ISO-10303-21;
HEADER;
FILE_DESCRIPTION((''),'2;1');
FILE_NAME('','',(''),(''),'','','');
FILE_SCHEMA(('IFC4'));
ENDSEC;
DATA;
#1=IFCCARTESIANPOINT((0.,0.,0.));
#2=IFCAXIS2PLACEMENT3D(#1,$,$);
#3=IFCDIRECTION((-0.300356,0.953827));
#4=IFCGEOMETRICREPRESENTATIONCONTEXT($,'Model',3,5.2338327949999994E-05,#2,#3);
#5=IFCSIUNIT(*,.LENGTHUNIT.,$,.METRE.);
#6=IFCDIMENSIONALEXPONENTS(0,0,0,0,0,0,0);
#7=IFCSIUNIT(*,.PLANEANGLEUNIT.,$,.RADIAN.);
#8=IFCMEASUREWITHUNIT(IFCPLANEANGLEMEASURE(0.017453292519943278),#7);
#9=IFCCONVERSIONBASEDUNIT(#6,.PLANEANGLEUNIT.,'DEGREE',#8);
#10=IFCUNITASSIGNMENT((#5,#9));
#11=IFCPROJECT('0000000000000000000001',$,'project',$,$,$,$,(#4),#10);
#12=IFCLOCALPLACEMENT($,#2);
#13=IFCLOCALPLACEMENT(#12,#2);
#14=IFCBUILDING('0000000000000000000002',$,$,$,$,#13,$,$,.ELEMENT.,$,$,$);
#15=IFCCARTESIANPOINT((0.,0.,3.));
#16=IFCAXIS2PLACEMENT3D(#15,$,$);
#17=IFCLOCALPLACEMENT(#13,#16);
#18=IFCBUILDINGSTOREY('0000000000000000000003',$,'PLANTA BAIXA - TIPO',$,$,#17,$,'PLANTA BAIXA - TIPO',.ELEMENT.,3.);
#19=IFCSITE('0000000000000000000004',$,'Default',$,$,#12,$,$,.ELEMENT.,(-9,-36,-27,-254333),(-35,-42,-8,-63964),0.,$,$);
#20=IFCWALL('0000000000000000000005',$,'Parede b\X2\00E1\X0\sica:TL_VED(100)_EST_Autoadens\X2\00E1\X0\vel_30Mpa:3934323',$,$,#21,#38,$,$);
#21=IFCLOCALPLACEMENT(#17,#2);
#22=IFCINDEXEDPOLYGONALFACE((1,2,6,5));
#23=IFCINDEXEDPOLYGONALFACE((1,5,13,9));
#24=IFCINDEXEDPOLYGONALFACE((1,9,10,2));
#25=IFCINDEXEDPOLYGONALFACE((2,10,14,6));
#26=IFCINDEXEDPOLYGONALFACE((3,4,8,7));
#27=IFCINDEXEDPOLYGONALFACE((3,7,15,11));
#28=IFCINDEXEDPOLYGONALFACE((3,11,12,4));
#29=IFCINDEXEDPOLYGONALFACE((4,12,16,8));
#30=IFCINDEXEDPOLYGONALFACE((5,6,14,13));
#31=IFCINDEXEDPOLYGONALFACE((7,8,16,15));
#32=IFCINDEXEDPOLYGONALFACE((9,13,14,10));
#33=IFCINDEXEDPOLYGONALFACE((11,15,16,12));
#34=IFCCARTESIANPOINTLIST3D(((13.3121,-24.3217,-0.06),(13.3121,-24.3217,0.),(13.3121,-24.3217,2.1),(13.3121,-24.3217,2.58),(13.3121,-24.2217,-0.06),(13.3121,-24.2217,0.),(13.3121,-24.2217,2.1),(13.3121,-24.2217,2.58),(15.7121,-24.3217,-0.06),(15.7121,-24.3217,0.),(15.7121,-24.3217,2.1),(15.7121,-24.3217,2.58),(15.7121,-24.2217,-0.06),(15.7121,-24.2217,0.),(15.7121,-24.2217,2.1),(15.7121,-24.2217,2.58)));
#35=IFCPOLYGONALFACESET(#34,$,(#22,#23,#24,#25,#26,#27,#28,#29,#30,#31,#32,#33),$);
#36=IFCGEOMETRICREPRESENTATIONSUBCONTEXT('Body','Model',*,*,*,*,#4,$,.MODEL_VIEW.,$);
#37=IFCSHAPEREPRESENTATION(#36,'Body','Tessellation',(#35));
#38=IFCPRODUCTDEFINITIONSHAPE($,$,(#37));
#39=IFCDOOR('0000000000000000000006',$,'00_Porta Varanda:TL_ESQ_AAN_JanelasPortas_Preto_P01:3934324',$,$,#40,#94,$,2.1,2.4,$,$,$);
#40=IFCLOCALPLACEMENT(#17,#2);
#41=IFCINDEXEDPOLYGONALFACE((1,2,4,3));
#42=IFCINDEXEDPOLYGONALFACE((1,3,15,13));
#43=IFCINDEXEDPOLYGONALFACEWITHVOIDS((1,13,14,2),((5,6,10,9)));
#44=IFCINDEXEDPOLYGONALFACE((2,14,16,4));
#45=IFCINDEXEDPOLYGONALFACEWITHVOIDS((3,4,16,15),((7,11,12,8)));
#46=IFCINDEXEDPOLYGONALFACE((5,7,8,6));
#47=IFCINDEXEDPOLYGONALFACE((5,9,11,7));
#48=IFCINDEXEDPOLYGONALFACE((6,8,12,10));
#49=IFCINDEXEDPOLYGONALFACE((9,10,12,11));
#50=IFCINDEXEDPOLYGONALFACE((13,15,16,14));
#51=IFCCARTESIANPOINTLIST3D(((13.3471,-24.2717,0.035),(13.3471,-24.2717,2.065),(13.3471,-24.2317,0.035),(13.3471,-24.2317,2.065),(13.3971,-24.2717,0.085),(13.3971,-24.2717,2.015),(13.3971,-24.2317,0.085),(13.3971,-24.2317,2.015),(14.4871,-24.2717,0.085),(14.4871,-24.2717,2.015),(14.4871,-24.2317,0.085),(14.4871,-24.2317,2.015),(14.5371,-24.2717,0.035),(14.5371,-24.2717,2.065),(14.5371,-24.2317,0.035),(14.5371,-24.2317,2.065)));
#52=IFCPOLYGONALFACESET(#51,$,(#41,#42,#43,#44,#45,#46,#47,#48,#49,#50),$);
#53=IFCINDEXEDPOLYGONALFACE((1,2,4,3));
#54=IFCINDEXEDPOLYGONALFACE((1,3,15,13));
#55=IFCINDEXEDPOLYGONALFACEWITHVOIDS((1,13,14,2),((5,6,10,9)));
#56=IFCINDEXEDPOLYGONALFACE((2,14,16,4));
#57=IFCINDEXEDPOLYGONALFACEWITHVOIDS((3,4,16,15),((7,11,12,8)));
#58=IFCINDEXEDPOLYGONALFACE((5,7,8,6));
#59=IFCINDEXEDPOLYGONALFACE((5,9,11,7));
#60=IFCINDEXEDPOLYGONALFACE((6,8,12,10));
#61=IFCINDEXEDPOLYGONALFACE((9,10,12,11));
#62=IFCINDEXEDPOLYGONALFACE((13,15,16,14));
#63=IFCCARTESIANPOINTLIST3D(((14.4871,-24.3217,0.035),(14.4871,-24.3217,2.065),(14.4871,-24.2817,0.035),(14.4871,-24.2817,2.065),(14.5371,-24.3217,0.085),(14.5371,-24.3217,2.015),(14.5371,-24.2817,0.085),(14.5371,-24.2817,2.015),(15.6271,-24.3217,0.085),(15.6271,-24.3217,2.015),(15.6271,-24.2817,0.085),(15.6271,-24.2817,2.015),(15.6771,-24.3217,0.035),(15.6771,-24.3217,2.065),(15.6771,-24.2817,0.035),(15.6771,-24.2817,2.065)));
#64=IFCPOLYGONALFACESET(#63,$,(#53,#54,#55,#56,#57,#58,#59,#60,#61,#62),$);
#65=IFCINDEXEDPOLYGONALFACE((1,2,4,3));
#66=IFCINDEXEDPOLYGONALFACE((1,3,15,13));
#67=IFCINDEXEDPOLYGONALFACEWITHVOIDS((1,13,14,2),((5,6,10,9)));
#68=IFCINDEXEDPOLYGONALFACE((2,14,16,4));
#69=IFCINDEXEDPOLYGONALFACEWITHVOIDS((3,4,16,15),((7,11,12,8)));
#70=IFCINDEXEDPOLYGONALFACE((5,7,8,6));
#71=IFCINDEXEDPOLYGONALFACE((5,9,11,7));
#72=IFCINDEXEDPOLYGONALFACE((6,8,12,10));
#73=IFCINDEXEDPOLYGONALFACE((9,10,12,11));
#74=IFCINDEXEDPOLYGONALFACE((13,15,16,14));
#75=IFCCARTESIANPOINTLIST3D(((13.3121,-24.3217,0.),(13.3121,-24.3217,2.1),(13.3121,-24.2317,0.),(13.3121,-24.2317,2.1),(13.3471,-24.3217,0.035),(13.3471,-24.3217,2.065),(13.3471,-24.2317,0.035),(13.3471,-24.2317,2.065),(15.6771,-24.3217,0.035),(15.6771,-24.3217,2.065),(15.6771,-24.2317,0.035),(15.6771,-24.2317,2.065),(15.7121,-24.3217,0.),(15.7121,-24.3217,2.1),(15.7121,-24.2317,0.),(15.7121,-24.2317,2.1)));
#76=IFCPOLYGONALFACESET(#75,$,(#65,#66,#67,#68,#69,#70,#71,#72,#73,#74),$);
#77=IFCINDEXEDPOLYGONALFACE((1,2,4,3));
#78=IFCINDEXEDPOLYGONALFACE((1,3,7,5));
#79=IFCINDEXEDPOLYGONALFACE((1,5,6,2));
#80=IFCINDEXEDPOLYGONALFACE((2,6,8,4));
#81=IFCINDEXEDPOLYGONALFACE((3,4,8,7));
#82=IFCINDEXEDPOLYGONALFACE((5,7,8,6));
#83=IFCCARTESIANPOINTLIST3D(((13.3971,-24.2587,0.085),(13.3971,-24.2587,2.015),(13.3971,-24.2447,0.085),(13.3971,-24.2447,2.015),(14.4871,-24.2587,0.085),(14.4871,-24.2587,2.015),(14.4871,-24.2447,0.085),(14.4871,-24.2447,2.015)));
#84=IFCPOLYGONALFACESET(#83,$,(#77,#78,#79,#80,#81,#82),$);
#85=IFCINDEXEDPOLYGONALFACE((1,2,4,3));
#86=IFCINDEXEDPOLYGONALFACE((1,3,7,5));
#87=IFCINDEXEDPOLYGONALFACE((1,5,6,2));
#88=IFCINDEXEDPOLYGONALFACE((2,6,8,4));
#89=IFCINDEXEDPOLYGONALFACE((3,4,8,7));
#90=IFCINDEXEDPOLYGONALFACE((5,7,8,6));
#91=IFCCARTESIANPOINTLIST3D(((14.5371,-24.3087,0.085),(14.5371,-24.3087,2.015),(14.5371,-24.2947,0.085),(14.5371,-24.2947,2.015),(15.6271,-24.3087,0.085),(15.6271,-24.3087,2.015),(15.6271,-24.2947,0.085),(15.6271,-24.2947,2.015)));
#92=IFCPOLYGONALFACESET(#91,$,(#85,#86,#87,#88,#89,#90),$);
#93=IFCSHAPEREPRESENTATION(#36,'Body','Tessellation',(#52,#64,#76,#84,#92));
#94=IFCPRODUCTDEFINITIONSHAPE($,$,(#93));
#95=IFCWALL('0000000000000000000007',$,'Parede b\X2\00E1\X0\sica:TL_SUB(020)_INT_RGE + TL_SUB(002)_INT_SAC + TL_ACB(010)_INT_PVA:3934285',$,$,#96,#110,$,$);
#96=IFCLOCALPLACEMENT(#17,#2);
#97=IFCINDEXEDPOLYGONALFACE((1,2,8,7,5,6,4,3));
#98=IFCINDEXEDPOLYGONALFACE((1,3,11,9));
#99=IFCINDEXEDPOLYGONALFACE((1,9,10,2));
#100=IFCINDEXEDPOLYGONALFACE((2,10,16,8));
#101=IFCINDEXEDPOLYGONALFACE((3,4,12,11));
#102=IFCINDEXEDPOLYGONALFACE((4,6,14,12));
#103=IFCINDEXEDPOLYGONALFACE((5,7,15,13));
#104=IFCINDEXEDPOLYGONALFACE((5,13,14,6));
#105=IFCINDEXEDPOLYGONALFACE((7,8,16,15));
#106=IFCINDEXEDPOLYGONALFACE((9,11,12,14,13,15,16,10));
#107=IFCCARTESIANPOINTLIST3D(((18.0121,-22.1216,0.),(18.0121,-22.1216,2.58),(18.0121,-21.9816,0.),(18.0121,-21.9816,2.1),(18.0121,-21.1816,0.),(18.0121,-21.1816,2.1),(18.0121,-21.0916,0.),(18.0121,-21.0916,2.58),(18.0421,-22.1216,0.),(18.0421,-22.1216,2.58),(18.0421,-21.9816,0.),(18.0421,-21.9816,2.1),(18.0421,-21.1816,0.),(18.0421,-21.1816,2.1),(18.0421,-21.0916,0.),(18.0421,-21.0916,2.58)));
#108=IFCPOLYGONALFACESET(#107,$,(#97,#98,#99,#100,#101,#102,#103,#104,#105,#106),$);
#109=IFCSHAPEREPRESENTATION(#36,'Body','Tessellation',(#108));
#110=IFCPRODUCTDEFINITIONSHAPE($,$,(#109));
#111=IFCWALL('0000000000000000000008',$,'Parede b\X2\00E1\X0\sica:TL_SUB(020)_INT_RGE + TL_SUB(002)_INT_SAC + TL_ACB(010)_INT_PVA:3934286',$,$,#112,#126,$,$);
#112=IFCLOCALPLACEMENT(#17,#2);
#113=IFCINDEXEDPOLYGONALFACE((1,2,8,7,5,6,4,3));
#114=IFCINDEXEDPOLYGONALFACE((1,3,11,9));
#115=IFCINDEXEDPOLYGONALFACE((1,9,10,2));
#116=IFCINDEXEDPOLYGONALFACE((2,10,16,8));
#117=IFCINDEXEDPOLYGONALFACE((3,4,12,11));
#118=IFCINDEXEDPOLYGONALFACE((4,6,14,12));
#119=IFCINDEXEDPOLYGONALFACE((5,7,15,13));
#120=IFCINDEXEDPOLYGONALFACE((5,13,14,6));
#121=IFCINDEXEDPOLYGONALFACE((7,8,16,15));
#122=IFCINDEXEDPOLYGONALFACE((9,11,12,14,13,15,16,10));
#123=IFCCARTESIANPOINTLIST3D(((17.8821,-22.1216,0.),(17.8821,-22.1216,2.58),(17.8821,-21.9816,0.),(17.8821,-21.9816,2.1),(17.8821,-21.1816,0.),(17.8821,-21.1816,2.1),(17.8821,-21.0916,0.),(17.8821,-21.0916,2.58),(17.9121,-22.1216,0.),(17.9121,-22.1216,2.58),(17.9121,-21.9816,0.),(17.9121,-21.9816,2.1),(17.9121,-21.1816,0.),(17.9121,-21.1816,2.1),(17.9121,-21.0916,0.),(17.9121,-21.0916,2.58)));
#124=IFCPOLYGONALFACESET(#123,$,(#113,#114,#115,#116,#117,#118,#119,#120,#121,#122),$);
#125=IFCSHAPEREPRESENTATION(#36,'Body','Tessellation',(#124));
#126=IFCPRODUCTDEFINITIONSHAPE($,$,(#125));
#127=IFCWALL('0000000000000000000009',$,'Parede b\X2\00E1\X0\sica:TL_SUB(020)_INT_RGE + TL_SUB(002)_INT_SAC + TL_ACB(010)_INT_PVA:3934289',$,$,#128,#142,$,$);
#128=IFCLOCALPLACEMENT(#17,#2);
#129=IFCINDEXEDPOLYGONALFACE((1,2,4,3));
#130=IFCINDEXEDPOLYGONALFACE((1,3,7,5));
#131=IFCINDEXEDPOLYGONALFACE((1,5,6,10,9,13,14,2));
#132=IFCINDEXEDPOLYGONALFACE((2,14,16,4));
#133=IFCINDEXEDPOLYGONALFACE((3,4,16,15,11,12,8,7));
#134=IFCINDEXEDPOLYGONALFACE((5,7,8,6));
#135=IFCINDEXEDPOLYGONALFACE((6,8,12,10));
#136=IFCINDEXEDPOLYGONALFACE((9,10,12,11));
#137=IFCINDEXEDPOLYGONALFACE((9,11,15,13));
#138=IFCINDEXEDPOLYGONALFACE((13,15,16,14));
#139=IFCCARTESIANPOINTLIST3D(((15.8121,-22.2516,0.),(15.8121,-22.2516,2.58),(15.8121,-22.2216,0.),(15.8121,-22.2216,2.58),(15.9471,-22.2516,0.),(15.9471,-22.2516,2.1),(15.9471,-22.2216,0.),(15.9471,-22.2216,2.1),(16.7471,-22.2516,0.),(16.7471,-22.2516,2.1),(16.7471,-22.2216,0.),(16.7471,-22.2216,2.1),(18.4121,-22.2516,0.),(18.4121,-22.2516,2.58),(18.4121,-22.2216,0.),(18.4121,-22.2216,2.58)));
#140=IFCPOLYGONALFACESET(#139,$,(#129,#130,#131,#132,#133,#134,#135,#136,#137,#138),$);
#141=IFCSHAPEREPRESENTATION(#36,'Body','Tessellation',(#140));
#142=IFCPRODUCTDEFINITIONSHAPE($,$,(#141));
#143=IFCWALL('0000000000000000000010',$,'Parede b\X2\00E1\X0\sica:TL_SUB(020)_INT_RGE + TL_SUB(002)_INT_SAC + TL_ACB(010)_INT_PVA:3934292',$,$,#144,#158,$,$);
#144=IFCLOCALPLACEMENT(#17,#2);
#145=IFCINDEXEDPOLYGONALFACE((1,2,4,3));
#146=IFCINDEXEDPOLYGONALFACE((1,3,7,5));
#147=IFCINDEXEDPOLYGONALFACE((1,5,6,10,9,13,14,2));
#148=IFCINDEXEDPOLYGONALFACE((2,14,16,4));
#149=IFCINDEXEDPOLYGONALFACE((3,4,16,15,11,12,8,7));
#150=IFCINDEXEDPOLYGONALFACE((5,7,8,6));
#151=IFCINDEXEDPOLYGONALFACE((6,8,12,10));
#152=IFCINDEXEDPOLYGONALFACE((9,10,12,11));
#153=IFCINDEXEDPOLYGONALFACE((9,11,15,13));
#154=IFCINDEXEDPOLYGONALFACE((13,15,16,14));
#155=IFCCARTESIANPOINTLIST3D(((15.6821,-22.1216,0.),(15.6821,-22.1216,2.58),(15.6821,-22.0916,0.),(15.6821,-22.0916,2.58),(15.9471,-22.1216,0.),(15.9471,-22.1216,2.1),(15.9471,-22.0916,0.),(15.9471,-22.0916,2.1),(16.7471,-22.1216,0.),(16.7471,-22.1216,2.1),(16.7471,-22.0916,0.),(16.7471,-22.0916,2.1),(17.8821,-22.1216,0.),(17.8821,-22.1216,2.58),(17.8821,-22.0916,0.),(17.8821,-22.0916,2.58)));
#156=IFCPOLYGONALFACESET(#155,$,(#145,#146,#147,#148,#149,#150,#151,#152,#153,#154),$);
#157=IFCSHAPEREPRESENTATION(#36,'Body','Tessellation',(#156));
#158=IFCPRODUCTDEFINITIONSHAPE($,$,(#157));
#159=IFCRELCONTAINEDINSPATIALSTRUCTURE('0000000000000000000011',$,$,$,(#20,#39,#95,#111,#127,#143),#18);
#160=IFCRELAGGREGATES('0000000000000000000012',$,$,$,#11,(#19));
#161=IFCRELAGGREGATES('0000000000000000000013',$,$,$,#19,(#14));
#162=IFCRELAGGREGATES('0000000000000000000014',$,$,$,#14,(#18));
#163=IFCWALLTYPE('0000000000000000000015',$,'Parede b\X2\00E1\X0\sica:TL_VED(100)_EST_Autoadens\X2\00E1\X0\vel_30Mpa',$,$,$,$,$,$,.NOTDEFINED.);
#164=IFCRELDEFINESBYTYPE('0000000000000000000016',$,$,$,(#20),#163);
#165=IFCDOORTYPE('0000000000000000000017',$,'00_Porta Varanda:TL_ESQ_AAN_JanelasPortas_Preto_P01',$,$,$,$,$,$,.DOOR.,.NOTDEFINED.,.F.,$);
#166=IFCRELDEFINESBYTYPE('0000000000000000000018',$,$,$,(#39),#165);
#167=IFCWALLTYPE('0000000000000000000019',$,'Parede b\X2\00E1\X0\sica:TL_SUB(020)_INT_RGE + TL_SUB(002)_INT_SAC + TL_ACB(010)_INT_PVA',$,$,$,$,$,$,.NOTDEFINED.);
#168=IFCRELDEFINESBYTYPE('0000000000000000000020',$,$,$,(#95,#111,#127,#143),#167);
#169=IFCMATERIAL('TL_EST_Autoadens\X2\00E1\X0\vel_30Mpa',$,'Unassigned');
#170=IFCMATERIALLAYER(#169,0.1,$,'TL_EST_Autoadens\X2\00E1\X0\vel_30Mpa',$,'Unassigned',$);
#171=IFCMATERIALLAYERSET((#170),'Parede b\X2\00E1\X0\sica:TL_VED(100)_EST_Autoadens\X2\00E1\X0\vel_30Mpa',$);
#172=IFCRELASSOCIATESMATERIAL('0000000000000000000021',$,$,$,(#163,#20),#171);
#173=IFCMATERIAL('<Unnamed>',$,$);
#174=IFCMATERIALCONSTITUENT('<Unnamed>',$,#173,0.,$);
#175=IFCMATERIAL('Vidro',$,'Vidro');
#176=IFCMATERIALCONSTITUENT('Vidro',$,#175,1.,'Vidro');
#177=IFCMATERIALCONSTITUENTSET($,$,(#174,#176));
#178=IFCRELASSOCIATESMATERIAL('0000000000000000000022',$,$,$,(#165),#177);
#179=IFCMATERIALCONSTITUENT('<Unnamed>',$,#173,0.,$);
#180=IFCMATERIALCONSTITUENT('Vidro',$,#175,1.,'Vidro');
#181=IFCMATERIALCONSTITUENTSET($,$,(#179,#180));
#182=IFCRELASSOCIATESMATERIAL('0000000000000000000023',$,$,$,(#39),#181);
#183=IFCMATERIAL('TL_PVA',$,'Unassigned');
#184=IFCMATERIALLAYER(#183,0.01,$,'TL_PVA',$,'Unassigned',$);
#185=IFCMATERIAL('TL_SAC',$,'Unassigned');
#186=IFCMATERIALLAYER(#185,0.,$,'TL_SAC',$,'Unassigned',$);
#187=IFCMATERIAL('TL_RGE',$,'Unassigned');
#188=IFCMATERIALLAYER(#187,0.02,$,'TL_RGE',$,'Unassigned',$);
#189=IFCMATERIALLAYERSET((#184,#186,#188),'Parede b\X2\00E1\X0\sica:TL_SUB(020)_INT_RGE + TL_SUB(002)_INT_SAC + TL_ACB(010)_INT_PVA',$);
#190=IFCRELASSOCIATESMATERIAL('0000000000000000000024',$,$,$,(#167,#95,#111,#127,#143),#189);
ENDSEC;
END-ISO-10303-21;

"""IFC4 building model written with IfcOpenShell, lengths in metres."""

from ifc_helpers import new_model, entity, si_unit, converted_unit, direction, frame, frame_2d, origin, place, context, subcontext, project, spatial, polyline, rectangle, outline, extrude, source, transform, mapped, material, layer, layer_set, layer_usage, constituent, constituent_set, type_object, type_shapes, element, fill, save


model = new_model("IFC4")

# Units and contexts
model_context = context("Model", 3, precision=5.2338327949999994e-05, world=origin(), true_north=direction((-0.300356, 0.953827)))
body_context = subcontext(model_context, "Body", "Model", "MODEL_VIEW")
ifc_project = project(units=[si_unit("LENGTHUNIT", "METRE"), converted_unit("PLANEANGLEUNIT", "DEGREE", entity("IfcPlaneAngleMeasure", 0.017453292519943278), si_unit("PLANEANGLEUNIT", "RADIAN"), dimensions=[0, 0, 0, 0, 0, 0, 0])], contexts=[model_context])

# Site, building, storey
site_placement = place(None, origin())
site = spatial("IfcSite", under=ifc_project, at=site_placement, Name="Default", CompositionType="ELEMENT", RefLatitude=(-9, -36, -27, -254333), RefLongitude=(-35, -42, -8, -63964), RefElevation=0.0)
building_placement = place(site_placement, origin())
building = spatial("IfcBuilding", under=site, at=building_placement, CompositionType="ELEMENT")
storey_placement = place(building_placement, frame((0.0, 0.0, 3.0)))
storey = spatial("IfcBuildingStorey", under=building, at=storey_placement, Name="PLANTA BAIXA - TIPO", LongName="PLANTA BAIXA - TIPO", CompositionType="ELEMENT", Elevation=3.0)

# Shared definitions
ifc_material_1 = material(Name="TL_EST_Autoadensável_30Mpa", Category="Unassigned")
ifc_layer_1 = layer(ifc_material_1, 0.1, Name="TL_EST_Autoadensável_30Mpa", Category="Unassigned")
ifc_layer_set_1 = layer_set([ifc_layer_1], Name="Parede básica:TL_VED(100)_EST_Autoadensável_30Mpa")
wall_type_1 = type_object("IfcWallType", Name="Parede básica:TL_VED(100)_EST_Autoadensável_30Mpa", PredefinedType="NOTDEFINED", material=ifc_layer_set_1)

# Wall, opening, door
ifc_layer_usage_1 = layer_usage(ifc_layer_set_1, "AXIS2", "NEGATIVE", 0.05)
wall_1_placement = place(storey_placement, frame((15.7121, -24.2717, -0.06), z_axis=(0.0, 0.0, 1.0), x_axis=(-1.0, 0.0, 0.0)))
wall_1 = element("IfcWall", 1, at=wall_1_placement, inside=storey, type_object=wall_type_1, material=ifc_layer_usage_1, Name="Parede básica:TL_VED(100)_EST_Autoadensável_30Mpa:3934323", context=body_context, shape_type="SweptSolid", body=[
    extrude(rectangle(XDim=2.4, YDim=0.1, at=frame_2d((1.2, 0.0), x_axis=(-1.0, 0.0))), origin(), (0.0, 0.0, 1.0), 2.64),
])
opening_1_placement = place(wall_1_placement, frame((2.4, 0.05, 0.06)))
opening_1 = element("IfcOpeningElement", 2, at=opening_1_placement, cuts=wall_1, PredefinedType="OPENING", context=body_context, shape_type="SweptSolid", body=[
    extrude(rectangle(XDim=2.1, YDim=2.4, at=frame_2d((1.05, 1.2), x_axis=(1.0, 0.0))), frame((0.0, 0.0, 0.0), z_axis=(0.0, -1.0, 0.0), x_axis=(0.0, 0.0, 1.0)), (0.0, 0.0, 1.0), 0.1),
])
ifc_material_2 = material(Name="<Unnamed>")
ifc_constituent_1 = constituent(ifc_material_2, Name="<Unnamed>", fraction=0.0)
ifc_material_3 = material(Name="Vidro", Category="Vidro")
ifc_constituent_2 = constituent(ifc_material_3, Name="Vidro", Category="Vidro", fraction=1.0)
ifc_constituent_set_1 = constituent_set(constituents=[ifc_constituent_1, ifc_constituent_2])
ifc_constituent_3 = constituent(ifc_material_2, Name="<Unnamed>", fraction=0.0)
ifc_constituent_4 = constituent(ifc_material_3, Name="Vidro", Category="Vidro", fraction=1.0)
ifc_constituent_set_2 = constituent_set(constituents=[ifc_constituent_3, ifc_constituent_4])
door_type = type_object("IfcDoorType", Name="00_Porta Varanda:TL_ESQ_AAN_JanelasPortas_Preto_P01", OperationType="NOTDEFINED", ParameterTakesPrecedence=False, PredefinedType="DOOR", material=ifc_constituent_set_2)
shared_shape = source(origin(), body_context, "Body", "SweptSolid", [
    extrude(outline(polyline([(-0.595, -1.015), (0.595, -1.015), (0.595, 1.015), (-0.595, 1.015), (-0.595, -1.015)]), holes=[polyline([(-0.545, 0.965), (0.545, 0.965), (0.545, -0.965), (-0.545, -0.965), (-0.545, 0.965)])]), frame((0.63, 0.09, 1.05), z_axis=(0.0, -1.0, 0.0), x_axis=(-1.0, 0.0, 0.0)), (0.0, 0.0, 1.0), 0.04),
    extrude(outline(polyline([(-0.595, -1.015), (0.595, -1.015), (0.595, 1.015), (-0.595, 1.015), (-0.595, -1.015)]), holes=[polyline([(-0.545, 0.965), (0.545, 0.965), (0.545, -0.965), (-0.545, -0.965), (-0.545, 0.965)])]), frame((1.77, 0.04, 1.05), z_axis=(0.0, -1.0, 0.0), x_axis=(1.0, 0.0, 0.0)), (0.0, 0.0, 1.0), 0.04),
    extrude(outline(polyline([(-1.2, -1.05), (1.2, -1.05), (1.2, 1.05), (-1.2, 1.05), (-1.2, -1.05)]), holes=[polyline([(-1.165, 1.015), (1.165, 1.015), (1.165, -1.015), (-1.165, -1.015), (-1.165, 1.015)])]), frame((1.2, 0.09, 1.05), z_axis=(0.0, -1.0, 0.0), x_axis=(1.0, 0.0, 0.0)), (0.0, 0.0, 1.0), 0.09),
    extrude(rectangle(XDim=1.09, YDim=0.014, at=frame_2d((0.0, 0.0), x_axis=(1.0, 0.0))), frame((0.63, 0.07, 0.085), z_axis=(0.0, 0.0, 1.0), x_axis=(-1.0, 0.0, 0.0)), (0.0, 0.0, 1.0), 1.93),
    extrude(rectangle(XDim=1.09, YDim=0.014, at=frame_2d((0.0, 0.0), x_axis=(1.0, 0.0))), frame((1.77, 0.02, 0.085), z_axis=(0.0, 0.0, 1.0), x_axis=(-1.0, 0.0, 0.0)), (0.0, 0.0, 1.0), 1.93),
])
type_shapes(door_type, [shared_shape])
door_placement = place(opening_1_placement, frame((0.0, 0.0, 0.0), z_axis=(0.0, 0.0, 1.0), x_axis=(-1.0, 0.0, 0.0)))
door = element("IfcDoor", 3, at=door_placement, inside=storey, type_object=door_type, material=ifc_constituent_set_1, Name="00_Porta Varanda:TL_ESQ_AAN_JanelasPortas_Preto_P01:3934324", OverallHeight=2.1, OverallWidth=2.4, context=body_context, shape_type="MappedRepresentation", body=[
    mapped(shared_shape, transform((0.0, 0.0, 0.0), scale=1.0)),
])
fill(opening_1, door)

# Walls, openings
ifc_material_4 = material(Name="TL_PVA", Category="Unassigned")
ifc_layer_2 = layer(ifc_material_4, 0.01, Name="TL_PVA", Category="Unassigned")
ifc_material_5 = material(Name="TL_SAC", Category="Unassigned")
ifc_layer_3 = layer(ifc_material_5, 0.0, Name="TL_SAC", Category="Unassigned")
ifc_material_6 = material(Name="TL_RGE", Category="Unassigned")
ifc_layer_4 = layer(ifc_material_6, 0.02, Name="TL_RGE", Category="Unassigned")
ifc_layer_set_2 = layer_set([ifc_layer_2, ifc_layer_3, ifc_layer_4], Name="Parede básica:TL_SUB(020)_INT_RGE + TL_SUB(002)_INT_SAC + TL_ACB(010)_INT_PVA")
ifc_layer_usage_2 = layer_usage(ifc_layer_set_2, "AXIS2", "POSITIVE", -0.015)
wall_type_2 = type_object("IfcWallType", Name="Parede básica:TL_SUB(020)_INT_RGE + TL_SUB(002)_INT_SAC + TL_ACB(010)_INT_PVA", PredefinedType="NOTDEFINED", material=ifc_layer_set_2)
wall_2_placement = place(storey_placement, frame((18.0271, -22.1216, 0.0), z_axis=(0.0, 0.0, 1.0), x_axis=(0.0, 1.0, 0.0)))
wall_2 = element("IfcWall", 4, at=wall_2_placement, inside=storey, type_object=wall_type_2, material=ifc_layer_usage_2, Name="Parede básica:TL_SUB(020)_INT_RGE + TL_SUB(002)_INT_SAC + TL_ACB(010)_INT_PVA:3934285", context=body_context, shape_type="SweptSolid", body=[
    extrude(rectangle(XDim=1.03, YDim=0.03, at=frame_2d((0.515, 0.0), x_axis=(-1.0, 0.0))), origin(), (0.0, 0.0, 1.0), 2.58),
])
opening_2_placement = place(wall_2_placement, frame((22.1216, 18.0271, 0.0)))
element("IfcOpeningElement", 5, at=opening_2_placement, cuts=wall_2, PredefinedType="OPENING", context=body_context, shape_type="SweptSolid", body=[
    extrude(rectangle(XDim=2.1, YDim=0.8, at=frame_2d((0.0, 0.0), x_axis=(0.0, 1.0))), frame((-21.5816, -19.4361, 1.05), z_axis=(0.0, 1.0, 0.0), x_axis=(-1.0, 0.0, 0.0)), (0.0, 0.0, 1.0), 3.048),
])
ifc_layer_usage_3 = layer_usage(ifc_layer_set_2, "AXIS2", "POSITIVE", -0.015)
wall_3_placement = place(storey_placement, frame((17.8971, -21.0916, 0.0), z_axis=(0.0, 0.0, 1.0), x_axis=(0.0, -1.0, 0.0)))
wall_3 = element("IfcWall", 6, at=wall_3_placement, inside=storey, type_object=wall_type_2, material=ifc_layer_usage_3, Name="Parede básica:TL_SUB(020)_INT_RGE + TL_SUB(002)_INT_SAC + TL_ACB(010)_INT_PVA:3934286", context=body_context, shape_type="SweptSolid", body=[
    extrude(rectangle(XDim=1.03, YDim=0.03, at=frame_2d((0.515, 0.0), x_axis=(-1.0, 0.0))), origin(), (0.0, 0.0, 1.0), 2.58),
])
opening_3_placement = place(wall_3_placement, frame((-21.0916, -17.8971, 0.0)))
element("IfcOpeningElement", 7, at=opening_3_placement, cuts=wall_3, PredefinedType="OPENING", context=body_context, shape_type="SweptSolid", body=[
    extrude(rectangle(XDim=2.1, YDim=0.8, at=frame_2d((0.0, 0.0), x_axis=(1.0, 0.0))), frame((21.5816, 16.3881, 1.05), z_axis=(0.0, 1.0, 0.0), x_axis=(0.0, 0.0, 1.0)), (0.0, 0.0, 1.0), 3.048),
])
ifc_layer_usage_4 = layer_usage(ifc_layer_set_2, "AXIS2", "POSITIVE", -0.015)
wall_4_placement = place(storey_placement, frame((15.8121, -22.2366, 0.0)))
wall_4 = element("IfcWall", 8, at=wall_4_placement, inside=storey, type_object=wall_type_2, material=ifc_layer_usage_4, Name="Parede básica:TL_SUB(020)_INT_RGE + TL_SUB(002)_INT_SAC + TL_ACB(010)_INT_PVA:3934289", context=body_context, shape_type="SweptSolid", body=[
    extrude(rectangle(XDim=2.6, YDim=0.03, at=frame_2d((1.3, 0.0), x_axis=(-1.0, 0.0))), origin(), (0.0, 0.0, 1.0), 2.58),
])
opening_4_placement = place(wall_4_placement, frame((-15.8121, 22.2366, 0.0)))
element("IfcOpeningElement", 9, at=opening_4_placement, cuts=wall_4, PredefinedType="OPENING", context=body_context, shape_type="SweptSolid", body=[
    extrude(rectangle(XDim=2.1, YDim=0.8, at=frame_2d((0.0, 0.0), x_axis=(1.0, 0.0))), frame((16.3471, -23.6456, 1.05), z_axis=(0.0, 1.0, 0.0), x_axis=(0.0, 0.0, 1.0)), (0.0, 0.0, 1.0), 3.048),
])
ifc_layer_usage_5 = layer_usage(ifc_layer_set_2, "AXIS2", "POSITIVE", -0.015)
wall_5_placement = place(storey_placement, frame((17.8821, -22.1066, 0.0), z_axis=(0.0, 0.0, 1.0), x_axis=(-1.0, 0.0, 0.0)))
wall_5 = element("IfcWall", 10, at=wall_5_placement, inside=storey, type_object=wall_type_2, material=ifc_layer_usage_5, Name="Parede básica:TL_SUB(020)_INT_RGE + TL_SUB(002)_INT_SAC + TL_ACB(010)_INT_PVA:3934292", context=body_context, shape_type="SweptSolid", body=[
    extrude(rectangle(XDim=2.2, YDim=0.03, at=frame_2d((1.1, 0.0), x_axis=(1.0, 0.0))), origin(), (0.0, 0.0, 1.0), 2.58),
])
opening_5_placement = place(wall_5_placement, frame((17.8821, -22.1066, 0.0)))
element("IfcOpeningElement", 11, at=opening_5_placement, cuts=wall_5, PredefinedType="OPENING", context=body_context, shape_type="SweptSolid", body=[
    extrude(rectangle(XDim=2.1, YDim=0.8, at=frame_2d((0.0, 0.0), x_axis=(0.0, 1.0))), frame((-16.3471, 20.5976, 1.05), z_axis=(0.0, 1.0, 0.0), x_axis=(-1.0, 0.0, 0.0)), (0.0, 0.0, 1.0), 3.048),
])

save(model, "model.ifc")
